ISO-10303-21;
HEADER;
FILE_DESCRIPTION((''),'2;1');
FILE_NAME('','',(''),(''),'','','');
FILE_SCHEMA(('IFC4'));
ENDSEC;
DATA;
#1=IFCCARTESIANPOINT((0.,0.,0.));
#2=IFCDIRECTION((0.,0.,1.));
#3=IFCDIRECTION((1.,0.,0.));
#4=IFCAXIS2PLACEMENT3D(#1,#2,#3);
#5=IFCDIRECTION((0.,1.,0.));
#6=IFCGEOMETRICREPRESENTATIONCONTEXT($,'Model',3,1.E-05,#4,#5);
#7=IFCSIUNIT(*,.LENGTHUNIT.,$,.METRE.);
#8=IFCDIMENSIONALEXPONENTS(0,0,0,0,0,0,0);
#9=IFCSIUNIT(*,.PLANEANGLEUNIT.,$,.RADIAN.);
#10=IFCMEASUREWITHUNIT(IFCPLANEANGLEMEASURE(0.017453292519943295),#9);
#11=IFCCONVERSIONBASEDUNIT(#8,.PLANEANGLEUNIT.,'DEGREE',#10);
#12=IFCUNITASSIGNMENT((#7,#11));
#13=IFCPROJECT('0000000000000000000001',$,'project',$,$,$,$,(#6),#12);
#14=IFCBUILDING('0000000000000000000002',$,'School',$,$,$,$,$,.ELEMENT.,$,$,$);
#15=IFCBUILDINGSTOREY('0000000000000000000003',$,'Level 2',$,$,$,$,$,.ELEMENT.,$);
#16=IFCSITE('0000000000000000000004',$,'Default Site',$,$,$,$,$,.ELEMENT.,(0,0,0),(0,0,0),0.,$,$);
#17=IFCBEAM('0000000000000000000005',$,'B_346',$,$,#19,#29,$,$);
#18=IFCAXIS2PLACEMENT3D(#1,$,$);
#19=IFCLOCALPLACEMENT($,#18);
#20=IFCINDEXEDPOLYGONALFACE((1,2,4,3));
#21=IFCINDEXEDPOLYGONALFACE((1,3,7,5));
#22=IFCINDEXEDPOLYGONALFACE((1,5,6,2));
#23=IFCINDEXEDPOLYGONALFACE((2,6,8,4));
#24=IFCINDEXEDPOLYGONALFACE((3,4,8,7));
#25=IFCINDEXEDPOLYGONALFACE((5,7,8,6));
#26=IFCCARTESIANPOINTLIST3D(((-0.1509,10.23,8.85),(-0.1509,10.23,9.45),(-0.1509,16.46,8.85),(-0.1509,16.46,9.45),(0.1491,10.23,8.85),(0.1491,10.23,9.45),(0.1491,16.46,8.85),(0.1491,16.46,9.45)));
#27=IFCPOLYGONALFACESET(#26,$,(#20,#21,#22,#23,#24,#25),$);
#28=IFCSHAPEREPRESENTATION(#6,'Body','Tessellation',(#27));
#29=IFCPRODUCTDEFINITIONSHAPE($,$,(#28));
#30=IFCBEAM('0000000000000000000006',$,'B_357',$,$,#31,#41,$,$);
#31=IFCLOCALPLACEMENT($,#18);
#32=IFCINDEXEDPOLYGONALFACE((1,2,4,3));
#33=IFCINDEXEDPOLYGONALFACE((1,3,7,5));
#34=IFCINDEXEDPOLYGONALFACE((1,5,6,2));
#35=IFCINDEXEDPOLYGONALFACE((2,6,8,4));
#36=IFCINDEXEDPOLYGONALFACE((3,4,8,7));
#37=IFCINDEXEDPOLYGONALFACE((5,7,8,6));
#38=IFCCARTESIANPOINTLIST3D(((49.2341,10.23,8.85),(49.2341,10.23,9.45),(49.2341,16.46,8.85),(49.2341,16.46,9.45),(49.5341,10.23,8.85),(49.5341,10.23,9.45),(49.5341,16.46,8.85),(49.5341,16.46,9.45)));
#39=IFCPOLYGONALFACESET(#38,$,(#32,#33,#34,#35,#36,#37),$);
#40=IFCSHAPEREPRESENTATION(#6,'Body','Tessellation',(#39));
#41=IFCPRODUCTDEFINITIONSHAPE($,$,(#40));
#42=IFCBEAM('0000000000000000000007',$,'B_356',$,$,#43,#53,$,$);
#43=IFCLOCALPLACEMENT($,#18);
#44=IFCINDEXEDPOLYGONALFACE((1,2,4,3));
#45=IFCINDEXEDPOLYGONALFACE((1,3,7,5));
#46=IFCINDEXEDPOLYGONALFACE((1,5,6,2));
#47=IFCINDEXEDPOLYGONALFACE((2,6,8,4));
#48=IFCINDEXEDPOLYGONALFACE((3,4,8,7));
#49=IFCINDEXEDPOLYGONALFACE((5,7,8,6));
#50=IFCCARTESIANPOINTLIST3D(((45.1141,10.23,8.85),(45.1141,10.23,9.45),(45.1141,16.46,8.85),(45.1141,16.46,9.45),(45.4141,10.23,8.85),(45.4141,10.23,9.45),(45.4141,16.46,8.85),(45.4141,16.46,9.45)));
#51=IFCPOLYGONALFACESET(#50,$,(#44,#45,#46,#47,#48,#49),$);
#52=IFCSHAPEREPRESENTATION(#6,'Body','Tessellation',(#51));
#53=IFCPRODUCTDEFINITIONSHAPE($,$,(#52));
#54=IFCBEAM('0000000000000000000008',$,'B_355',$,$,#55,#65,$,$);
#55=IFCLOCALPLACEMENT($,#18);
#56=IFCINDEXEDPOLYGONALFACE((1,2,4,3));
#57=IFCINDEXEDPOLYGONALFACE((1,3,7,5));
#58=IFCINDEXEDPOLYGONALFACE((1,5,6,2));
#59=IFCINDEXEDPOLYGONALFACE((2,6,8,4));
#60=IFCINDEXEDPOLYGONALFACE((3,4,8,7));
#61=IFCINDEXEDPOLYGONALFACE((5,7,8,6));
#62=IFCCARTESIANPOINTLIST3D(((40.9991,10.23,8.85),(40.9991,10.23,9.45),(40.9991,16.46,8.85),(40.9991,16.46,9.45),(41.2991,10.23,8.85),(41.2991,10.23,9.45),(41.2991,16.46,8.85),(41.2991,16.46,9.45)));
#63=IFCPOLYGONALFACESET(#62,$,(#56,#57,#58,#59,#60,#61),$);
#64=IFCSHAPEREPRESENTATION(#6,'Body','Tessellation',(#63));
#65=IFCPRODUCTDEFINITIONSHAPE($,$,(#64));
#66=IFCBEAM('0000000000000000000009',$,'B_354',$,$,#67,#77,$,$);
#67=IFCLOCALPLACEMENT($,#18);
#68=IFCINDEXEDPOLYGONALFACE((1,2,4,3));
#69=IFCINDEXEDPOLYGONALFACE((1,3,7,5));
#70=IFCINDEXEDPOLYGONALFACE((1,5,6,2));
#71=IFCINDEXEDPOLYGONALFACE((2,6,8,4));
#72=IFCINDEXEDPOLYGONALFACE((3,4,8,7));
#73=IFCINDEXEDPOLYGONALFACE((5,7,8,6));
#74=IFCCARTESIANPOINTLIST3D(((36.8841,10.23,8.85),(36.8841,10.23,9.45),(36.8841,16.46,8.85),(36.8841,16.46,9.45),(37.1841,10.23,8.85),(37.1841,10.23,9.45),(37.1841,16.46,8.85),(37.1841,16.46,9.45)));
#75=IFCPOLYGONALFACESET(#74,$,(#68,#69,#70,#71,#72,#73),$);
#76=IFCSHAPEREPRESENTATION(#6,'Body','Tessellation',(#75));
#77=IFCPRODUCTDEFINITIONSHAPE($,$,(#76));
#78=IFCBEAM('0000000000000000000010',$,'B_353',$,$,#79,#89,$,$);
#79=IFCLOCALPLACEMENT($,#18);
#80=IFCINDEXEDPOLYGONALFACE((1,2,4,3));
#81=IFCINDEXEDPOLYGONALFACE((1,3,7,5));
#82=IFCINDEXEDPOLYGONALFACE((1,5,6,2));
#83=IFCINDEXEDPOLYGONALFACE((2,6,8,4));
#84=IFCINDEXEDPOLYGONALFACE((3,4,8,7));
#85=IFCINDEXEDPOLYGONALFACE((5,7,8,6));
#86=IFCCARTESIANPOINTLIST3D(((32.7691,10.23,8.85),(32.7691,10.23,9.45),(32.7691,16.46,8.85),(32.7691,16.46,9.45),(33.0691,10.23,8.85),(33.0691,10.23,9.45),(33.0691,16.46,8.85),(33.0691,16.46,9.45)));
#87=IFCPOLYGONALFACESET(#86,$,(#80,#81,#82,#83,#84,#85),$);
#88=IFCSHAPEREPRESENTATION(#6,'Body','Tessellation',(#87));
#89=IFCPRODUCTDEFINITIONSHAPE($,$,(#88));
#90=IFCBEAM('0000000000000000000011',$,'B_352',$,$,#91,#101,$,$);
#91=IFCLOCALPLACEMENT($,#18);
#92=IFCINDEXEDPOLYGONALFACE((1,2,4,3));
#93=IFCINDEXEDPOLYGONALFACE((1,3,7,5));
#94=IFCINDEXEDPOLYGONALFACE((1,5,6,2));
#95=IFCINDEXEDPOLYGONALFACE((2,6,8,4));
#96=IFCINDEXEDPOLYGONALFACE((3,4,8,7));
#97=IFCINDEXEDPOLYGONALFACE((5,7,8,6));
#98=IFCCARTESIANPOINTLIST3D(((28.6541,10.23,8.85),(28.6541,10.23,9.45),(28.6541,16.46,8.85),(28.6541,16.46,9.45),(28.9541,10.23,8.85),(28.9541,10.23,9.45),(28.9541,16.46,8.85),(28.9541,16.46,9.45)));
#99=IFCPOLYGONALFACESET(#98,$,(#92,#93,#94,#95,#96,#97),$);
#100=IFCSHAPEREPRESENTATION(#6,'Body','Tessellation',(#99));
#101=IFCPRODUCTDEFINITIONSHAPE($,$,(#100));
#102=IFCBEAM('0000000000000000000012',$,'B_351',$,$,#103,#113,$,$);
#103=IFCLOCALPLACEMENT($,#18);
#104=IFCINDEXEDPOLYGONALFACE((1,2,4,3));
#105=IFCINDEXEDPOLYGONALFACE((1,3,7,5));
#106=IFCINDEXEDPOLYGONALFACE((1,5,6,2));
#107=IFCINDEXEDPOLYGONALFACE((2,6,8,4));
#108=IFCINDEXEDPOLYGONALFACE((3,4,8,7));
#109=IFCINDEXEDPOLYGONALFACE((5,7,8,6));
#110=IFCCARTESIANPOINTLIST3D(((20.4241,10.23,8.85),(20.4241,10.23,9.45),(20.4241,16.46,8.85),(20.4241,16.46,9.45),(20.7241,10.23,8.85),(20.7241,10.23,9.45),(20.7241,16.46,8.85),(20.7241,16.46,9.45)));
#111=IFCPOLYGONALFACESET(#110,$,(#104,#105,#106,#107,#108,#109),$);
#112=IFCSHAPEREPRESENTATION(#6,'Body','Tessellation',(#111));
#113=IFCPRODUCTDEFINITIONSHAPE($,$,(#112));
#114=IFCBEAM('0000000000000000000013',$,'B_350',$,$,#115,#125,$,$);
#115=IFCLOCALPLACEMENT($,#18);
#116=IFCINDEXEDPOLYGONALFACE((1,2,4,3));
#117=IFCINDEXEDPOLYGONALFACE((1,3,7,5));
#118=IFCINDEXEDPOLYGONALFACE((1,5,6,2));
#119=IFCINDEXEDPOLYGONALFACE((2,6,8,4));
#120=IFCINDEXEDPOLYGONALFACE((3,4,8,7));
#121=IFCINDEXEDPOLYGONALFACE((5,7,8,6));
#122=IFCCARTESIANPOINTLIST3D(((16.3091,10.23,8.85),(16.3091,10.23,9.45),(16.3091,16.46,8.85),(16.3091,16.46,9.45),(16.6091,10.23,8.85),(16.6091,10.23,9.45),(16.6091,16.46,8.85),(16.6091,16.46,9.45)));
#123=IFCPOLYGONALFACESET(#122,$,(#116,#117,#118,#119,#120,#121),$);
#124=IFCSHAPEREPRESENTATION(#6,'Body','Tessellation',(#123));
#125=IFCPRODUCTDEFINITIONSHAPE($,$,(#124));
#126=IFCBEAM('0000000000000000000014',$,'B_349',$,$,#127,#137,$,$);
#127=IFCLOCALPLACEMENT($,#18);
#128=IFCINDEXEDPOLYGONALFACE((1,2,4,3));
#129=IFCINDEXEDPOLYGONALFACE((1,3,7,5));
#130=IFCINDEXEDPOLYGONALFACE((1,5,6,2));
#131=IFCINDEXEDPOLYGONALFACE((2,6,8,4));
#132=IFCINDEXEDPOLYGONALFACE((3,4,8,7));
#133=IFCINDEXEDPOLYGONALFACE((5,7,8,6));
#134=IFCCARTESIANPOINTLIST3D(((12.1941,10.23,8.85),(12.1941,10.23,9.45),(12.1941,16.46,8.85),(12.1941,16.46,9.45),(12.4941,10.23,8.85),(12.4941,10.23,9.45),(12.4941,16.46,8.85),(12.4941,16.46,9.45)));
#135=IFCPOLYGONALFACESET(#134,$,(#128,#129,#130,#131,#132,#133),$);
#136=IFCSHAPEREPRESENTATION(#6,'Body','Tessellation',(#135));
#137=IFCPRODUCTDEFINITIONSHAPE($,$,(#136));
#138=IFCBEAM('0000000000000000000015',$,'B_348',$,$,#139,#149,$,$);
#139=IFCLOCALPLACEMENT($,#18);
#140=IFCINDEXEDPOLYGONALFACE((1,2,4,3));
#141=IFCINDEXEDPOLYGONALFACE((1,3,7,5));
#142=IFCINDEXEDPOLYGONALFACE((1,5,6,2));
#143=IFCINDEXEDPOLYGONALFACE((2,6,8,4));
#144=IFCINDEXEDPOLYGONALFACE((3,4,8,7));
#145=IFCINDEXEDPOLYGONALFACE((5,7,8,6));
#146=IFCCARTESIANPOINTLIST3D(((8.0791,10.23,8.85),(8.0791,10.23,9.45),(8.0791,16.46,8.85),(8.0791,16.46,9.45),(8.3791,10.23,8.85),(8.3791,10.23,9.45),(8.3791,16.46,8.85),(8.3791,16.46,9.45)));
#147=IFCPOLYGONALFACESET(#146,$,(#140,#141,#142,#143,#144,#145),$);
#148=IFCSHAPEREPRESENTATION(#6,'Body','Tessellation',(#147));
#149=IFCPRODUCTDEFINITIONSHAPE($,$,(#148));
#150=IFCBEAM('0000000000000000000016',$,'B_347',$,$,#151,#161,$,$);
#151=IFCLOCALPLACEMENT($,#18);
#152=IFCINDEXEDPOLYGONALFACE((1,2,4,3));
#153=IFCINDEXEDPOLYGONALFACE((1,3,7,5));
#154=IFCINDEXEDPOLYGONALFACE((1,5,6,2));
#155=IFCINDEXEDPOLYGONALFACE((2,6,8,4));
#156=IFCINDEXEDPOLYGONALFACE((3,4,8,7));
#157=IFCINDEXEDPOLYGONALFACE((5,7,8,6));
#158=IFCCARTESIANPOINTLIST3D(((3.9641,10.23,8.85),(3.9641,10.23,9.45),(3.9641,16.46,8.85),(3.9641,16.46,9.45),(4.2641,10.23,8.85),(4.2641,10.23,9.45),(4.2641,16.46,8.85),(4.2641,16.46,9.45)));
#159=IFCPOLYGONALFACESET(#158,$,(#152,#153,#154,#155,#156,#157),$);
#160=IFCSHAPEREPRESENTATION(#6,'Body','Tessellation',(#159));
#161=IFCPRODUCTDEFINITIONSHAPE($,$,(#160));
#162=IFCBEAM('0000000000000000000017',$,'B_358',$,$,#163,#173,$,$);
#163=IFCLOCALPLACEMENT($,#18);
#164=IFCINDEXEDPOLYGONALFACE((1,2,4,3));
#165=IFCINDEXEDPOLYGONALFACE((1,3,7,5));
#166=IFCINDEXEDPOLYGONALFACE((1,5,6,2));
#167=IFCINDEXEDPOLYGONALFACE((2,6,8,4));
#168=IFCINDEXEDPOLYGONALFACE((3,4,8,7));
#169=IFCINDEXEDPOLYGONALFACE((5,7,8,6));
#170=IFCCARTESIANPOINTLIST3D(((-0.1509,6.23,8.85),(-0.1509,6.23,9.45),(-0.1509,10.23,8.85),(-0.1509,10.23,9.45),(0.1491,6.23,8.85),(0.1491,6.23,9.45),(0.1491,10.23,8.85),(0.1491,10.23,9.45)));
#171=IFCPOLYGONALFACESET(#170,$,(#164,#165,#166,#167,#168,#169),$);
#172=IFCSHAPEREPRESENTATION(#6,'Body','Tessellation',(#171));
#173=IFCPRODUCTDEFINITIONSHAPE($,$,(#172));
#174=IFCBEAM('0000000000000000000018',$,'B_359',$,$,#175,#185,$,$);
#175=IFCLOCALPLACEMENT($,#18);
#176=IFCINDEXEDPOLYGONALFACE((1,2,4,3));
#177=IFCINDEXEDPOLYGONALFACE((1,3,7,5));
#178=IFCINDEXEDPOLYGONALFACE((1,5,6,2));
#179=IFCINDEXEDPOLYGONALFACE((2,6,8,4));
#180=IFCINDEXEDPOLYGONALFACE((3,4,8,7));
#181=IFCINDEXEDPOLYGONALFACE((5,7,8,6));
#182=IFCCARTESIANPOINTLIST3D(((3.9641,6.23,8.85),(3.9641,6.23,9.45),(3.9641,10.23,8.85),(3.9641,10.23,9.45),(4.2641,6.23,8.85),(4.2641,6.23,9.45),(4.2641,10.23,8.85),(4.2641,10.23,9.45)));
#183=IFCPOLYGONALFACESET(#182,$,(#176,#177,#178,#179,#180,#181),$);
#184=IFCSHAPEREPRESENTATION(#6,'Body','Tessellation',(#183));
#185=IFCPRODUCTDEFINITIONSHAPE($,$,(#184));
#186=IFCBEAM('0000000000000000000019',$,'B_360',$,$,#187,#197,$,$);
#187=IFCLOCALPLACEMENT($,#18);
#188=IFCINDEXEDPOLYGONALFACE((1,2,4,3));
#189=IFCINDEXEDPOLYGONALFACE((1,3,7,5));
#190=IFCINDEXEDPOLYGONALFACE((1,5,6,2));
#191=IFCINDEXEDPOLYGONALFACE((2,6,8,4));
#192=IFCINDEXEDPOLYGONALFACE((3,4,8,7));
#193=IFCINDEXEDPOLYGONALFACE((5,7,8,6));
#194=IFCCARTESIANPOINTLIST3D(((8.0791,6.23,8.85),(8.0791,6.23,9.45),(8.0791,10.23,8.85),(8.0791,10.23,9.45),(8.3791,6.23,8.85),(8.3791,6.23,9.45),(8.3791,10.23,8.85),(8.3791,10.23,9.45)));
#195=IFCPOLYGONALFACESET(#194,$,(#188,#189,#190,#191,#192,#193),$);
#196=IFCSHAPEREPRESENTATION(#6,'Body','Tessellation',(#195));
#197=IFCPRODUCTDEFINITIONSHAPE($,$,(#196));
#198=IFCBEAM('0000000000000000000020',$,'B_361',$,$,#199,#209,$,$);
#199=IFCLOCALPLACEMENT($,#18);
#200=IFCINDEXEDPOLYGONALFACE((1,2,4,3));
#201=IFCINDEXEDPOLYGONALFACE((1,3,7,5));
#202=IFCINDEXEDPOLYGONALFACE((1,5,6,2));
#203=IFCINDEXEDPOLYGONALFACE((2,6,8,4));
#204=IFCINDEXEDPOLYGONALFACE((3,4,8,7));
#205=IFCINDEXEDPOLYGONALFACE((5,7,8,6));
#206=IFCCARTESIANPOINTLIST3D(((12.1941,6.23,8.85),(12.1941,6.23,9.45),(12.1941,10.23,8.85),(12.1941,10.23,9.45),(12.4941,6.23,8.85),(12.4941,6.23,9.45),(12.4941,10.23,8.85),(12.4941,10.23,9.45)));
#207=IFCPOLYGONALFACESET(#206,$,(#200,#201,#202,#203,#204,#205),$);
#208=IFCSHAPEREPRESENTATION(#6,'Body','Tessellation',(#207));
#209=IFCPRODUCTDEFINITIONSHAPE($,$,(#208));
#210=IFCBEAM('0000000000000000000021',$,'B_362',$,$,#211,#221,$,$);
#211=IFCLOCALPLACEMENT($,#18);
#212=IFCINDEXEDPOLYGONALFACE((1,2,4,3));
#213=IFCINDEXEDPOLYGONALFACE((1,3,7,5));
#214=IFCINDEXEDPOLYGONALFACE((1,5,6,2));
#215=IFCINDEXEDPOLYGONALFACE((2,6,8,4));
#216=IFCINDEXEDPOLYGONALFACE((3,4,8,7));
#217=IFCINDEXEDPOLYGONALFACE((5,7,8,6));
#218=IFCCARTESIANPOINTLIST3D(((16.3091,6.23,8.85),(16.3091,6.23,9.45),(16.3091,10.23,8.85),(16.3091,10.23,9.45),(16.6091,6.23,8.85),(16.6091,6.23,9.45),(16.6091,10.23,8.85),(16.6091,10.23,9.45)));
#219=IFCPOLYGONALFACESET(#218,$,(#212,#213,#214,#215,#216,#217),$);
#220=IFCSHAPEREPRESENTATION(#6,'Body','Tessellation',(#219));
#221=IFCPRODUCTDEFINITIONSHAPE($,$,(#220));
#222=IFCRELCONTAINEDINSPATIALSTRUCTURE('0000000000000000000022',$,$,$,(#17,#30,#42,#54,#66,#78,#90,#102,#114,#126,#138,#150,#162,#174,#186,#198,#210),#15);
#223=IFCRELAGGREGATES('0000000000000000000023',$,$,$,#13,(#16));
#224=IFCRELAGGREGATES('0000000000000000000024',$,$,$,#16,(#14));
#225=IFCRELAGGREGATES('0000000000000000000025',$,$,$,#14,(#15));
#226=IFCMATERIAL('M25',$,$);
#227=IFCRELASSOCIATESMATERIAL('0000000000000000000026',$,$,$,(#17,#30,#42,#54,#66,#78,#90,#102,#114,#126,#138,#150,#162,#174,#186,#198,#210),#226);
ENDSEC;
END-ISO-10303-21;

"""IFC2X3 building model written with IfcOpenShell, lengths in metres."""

from ifc_helpers import new_model, entity, si_unit, converted_unit, direction, frame, frame_2d, origin_with_axes, place, context, project, spatial, rectangle, extrude, material, element, save


model = new_model("IFC2X3")

# Units and contexts
model_context = context("Model", 3, precision=1e-05, world=origin_with_axes(), true_north=direction((0.0, 1.0, 0.0)))
ifc_project = project(units=[si_unit("LENGTHUNIT", "METRE"), converted_unit("PLANEANGLEUNIT", "DEGREE", entity("IfcPlaneAngleMeasure", 0.017453292519943295), si_unit("PLANEANGLEUNIT", "RADIAN"), dimensions=[0, 0, 0, 0, 0, 0, 0])], contexts=[model_context])

# Site, building, storey
site = spatial("IfcSite", under=ifc_project, Name="Default Site", CompositionType="ELEMENT", RefLatitude=(0, 0, 0), RefLongitude=(0, 0, 0), RefElevation=0.0)
building = spatial("IfcBuilding", under=site, Name="School", CompositionType="ELEMENT")
storey = spatial("IfcBuildingStorey", under=building, Name="Level 2", CompositionType="ELEMENT")

# Beams
ifc_material = material(Name="M25")
placement = place(None, origin_with_axes())
element("IfcBeam", 1, at=placement, inside=storey, material=ifc_material, Name="B_346", context=model_context, shape_type="SweptSolid", body=[
    extrude(rectangle(XDim=0.3, YDim=0.6, at=frame_2d((0.0, 0.0), x_axis=(0.0, 1.0, 0.0))), frame((-0.0009, 10.23, 9.15), z_axis=(0.0, 1.0, 0.0), x_axis=(0.0, 0.0, -1.0)), (0.0, 0.0, 1.0), 6.23),
])
element("IfcBeam", 2, at=placement, inside=storey, material=ifc_material, Name="B_357", context=model_context, shape_type="SweptSolid", body=[
    extrude(rectangle(XDim=0.3, YDim=0.6, at=frame_2d((0.0, 0.0), x_axis=(0.0, 1.0, 0.0))), frame((49.3841, 10.23, 9.15), z_axis=(0.0, 1.0, 0.0), x_axis=(0.0, 0.0, -1.0)), (0.0, 0.0, 1.0), 6.23),
])
element("IfcBeam", 3, at=placement, inside=storey, material=ifc_material, Name="B_356", context=model_context, shape_type="SweptSolid", body=[
    extrude(rectangle(XDim=0.3, YDim=0.6, at=frame_2d((0.0, 0.0), x_axis=(0.0, 1.0, 0.0))), frame((45.2641, 10.23, 9.15), z_axis=(0.0, 1.0, 0.0), x_axis=(0.0, 0.0, -1.0)), (0.0, 0.0, 1.0), 6.23),
])
element("IfcBeam", 4, at=placement, inside=storey, material=ifc_material, Name="B_355", context=model_context, shape_type="SweptSolid", body=[
    extrude(rectangle(XDim=0.3, YDim=0.6, at=frame_2d((0.0, 0.0), x_axis=(0.0, 1.0, 0.0))), frame((41.1491, 10.23, 9.15), z_axis=(0.0, 1.0, 0.0), x_axis=(0.0, 0.0, -1.0)), (0.0, 0.0, 1.0), 6.23),
])
element("IfcBeam", 5, at=placement, inside=storey, material=ifc_material, Name="B_354", context=model_context, shape_type="SweptSolid", body=[
    extrude(rectangle(XDim=0.3, YDim=0.6, at=frame_2d((0.0, 0.0), x_axis=(0.0, 1.0, 0.0))), frame((37.0341, 10.23, 9.15), z_axis=(0.0, 1.0, 0.0), x_axis=(0.0, 0.0, -1.0)), (0.0, 0.0, 1.0), 6.23),
])
element("IfcBeam", 6, at=placement, inside=storey, material=ifc_material, Name="B_353", context=model_context, shape_type="SweptSolid", body=[
    extrude(rectangle(XDim=0.3, YDim=0.6, at=frame_2d((0.0, 0.0), x_axis=(0.0, 1.0, 0.0))), frame((32.9191, 10.23, 9.15), z_axis=(0.0, 1.0, 0.0), x_axis=(0.0, 0.0, -1.0)), (0.0, 0.0, 1.0), 6.23),
])
element("IfcBeam", 7, at=placement, inside=storey, material=ifc_material, Name="B_352", context=model_context, shape_type="SweptSolid", body=[
    extrude(rectangle(XDim=0.3, YDim=0.6, at=frame_2d((0.0, 0.0), x_axis=(0.0, 1.0, 0.0))), frame((28.8041, 10.23, 9.15), z_axis=(0.0, 1.0, 0.0), x_axis=(0.0, 0.0, -1.0)), (0.0, 0.0, 1.0), 6.23),
])
element("IfcBeam", 8, at=placement, inside=storey, material=ifc_material, Name="B_351", context=model_context, shape_type="SweptSolid", body=[
    extrude(rectangle(XDim=0.3, YDim=0.6, at=frame_2d((0.0, 0.0), x_axis=(0.0, 1.0, 0.0))), frame((20.5741, 10.23, 9.15), z_axis=(0.0, 1.0, 0.0), x_axis=(0.0, 0.0, -1.0)), (0.0, 0.0, 1.0), 6.23),
])
element("IfcBeam", 9, at=placement, inside=storey, material=ifc_material, Name="B_350", context=model_context, shape_type="SweptSolid", body=[
    extrude(rectangle(XDim=0.3, YDim=0.6, at=frame_2d((0.0, 0.0), x_axis=(0.0, 1.0, 0.0))), frame((16.4591, 10.23, 9.15), z_axis=(0.0, 1.0, 0.0), x_axis=(0.0, 0.0, -1.0)), (0.0, 0.0, 1.0), 6.23),
])
element("IfcBeam", 10, at=placement, inside=storey, material=ifc_material, Name="B_349", context=model_context, shape_type="SweptSolid", body=[
    extrude(rectangle(XDim=0.3, YDim=0.6, at=frame_2d((0.0, 0.0), x_axis=(0.0, 1.0, 0.0))), frame((12.3441, 10.23, 9.15), z_axis=(0.0, 1.0, 0.0), x_axis=(0.0, 0.0, -1.0)), (0.0, 0.0, 1.0), 6.23),
])
element("IfcBeam", 11, at=placement, inside=storey, material=ifc_material, Name="B_348", context=model_context, shape_type="SweptSolid", body=[
    extrude(rectangle(XDim=0.3, YDim=0.6, at=frame_2d((0.0, 0.0), x_axis=(0.0, 1.0, 0.0))), frame((8.2291, 10.23, 9.15), z_axis=(0.0, 1.0, 0.0), x_axis=(0.0, 0.0, -1.0)), (0.0, 0.0, 1.0), 6.23),
])
element("IfcBeam", 12, at=placement, inside=storey, material=ifc_material, Name="B_347", context=model_context, shape_type="SweptSolid", body=[
    extrude(rectangle(XDim=0.3, YDim=0.6, at=frame_2d((0.0, 0.0), x_axis=(0.0, 1.0, 0.0))), frame((4.1141, 10.23, 9.15), z_axis=(0.0, 1.0, 0.0), x_axis=(0.0, 0.0, -1.0)), (0.0, 0.0, 1.0), 6.23),
])
element("IfcBeam", 13, at=placement, inside=storey, material=ifc_material, Name="B_358", context=model_context, shape_type="SweptSolid", body=[
    extrude(rectangle(XDim=0.3, YDim=0.6, at=frame_2d((0.0, 0.0), x_axis=(0.0, 1.0, 0.0))), frame((-0.0009, 6.23, 9.15), z_axis=(0.0, 1.0, 0.0), x_axis=(0.0, 0.0, -1.0)), (0.0, 0.0, 1.0), 4.0),
])
element("IfcBeam", 14, at=placement, inside=storey, material=ifc_material, Name="B_359", context=model_context, shape_type="SweptSolid", body=[
    extrude(rectangle(XDim=0.3, YDim=0.6, at=frame_2d((0.0, 0.0), x_axis=(0.0, 1.0, 0.0))), frame((4.1141, 6.23, 9.15), z_axis=(0.0, 1.0, 0.0), x_axis=(0.0, 0.0, -1.0)), (0.0, 0.0, 1.0), 4.0),
])
element("IfcBeam", 15, at=placement, inside=storey, material=ifc_material, Name="B_360", context=model_context, shape_type="SweptSolid", body=[
    extrude(rectangle(XDim=0.3, YDim=0.6, at=frame_2d((0.0, 0.0), x_axis=(0.0, 1.0, 0.0))), frame((8.2291, 6.23, 9.15), z_axis=(0.0, 1.0, 0.0), x_axis=(0.0, 0.0, -1.0)), (0.0, 0.0, 1.0), 4.0),
])
element("IfcBeam", 16, at=placement, inside=storey, material=ifc_material, Name="B_361", context=model_context, shape_type="SweptSolid", body=[
    extrude(rectangle(XDim=0.3, YDim=0.6, at=frame_2d((0.0, 0.0), x_axis=(0.0, 1.0, 0.0))), frame((12.3441, 6.23, 9.15), z_axis=(0.0, 1.0, 0.0), x_axis=(0.0, 0.0, -1.0)), (0.0, 0.0, 1.0), 4.0),
])
element("IfcBeam", 17, at=placement, inside=storey, material=ifc_material, Name="B_362", context=model_context, shape_type="SweptSolid", body=[
    extrude(rectangle(XDim=0.3, YDim=0.6, at=frame_2d((0.0, 0.0), x_axis=(0.0, 1.0, 0.0))), frame((16.4591, 6.23, 9.15), z_axis=(0.0, 1.0, 0.0), x_axis=(0.0, 0.0, -1.0)), (0.0, 0.0, 1.0), 4.0),
])

save(model, "model.ifc")
